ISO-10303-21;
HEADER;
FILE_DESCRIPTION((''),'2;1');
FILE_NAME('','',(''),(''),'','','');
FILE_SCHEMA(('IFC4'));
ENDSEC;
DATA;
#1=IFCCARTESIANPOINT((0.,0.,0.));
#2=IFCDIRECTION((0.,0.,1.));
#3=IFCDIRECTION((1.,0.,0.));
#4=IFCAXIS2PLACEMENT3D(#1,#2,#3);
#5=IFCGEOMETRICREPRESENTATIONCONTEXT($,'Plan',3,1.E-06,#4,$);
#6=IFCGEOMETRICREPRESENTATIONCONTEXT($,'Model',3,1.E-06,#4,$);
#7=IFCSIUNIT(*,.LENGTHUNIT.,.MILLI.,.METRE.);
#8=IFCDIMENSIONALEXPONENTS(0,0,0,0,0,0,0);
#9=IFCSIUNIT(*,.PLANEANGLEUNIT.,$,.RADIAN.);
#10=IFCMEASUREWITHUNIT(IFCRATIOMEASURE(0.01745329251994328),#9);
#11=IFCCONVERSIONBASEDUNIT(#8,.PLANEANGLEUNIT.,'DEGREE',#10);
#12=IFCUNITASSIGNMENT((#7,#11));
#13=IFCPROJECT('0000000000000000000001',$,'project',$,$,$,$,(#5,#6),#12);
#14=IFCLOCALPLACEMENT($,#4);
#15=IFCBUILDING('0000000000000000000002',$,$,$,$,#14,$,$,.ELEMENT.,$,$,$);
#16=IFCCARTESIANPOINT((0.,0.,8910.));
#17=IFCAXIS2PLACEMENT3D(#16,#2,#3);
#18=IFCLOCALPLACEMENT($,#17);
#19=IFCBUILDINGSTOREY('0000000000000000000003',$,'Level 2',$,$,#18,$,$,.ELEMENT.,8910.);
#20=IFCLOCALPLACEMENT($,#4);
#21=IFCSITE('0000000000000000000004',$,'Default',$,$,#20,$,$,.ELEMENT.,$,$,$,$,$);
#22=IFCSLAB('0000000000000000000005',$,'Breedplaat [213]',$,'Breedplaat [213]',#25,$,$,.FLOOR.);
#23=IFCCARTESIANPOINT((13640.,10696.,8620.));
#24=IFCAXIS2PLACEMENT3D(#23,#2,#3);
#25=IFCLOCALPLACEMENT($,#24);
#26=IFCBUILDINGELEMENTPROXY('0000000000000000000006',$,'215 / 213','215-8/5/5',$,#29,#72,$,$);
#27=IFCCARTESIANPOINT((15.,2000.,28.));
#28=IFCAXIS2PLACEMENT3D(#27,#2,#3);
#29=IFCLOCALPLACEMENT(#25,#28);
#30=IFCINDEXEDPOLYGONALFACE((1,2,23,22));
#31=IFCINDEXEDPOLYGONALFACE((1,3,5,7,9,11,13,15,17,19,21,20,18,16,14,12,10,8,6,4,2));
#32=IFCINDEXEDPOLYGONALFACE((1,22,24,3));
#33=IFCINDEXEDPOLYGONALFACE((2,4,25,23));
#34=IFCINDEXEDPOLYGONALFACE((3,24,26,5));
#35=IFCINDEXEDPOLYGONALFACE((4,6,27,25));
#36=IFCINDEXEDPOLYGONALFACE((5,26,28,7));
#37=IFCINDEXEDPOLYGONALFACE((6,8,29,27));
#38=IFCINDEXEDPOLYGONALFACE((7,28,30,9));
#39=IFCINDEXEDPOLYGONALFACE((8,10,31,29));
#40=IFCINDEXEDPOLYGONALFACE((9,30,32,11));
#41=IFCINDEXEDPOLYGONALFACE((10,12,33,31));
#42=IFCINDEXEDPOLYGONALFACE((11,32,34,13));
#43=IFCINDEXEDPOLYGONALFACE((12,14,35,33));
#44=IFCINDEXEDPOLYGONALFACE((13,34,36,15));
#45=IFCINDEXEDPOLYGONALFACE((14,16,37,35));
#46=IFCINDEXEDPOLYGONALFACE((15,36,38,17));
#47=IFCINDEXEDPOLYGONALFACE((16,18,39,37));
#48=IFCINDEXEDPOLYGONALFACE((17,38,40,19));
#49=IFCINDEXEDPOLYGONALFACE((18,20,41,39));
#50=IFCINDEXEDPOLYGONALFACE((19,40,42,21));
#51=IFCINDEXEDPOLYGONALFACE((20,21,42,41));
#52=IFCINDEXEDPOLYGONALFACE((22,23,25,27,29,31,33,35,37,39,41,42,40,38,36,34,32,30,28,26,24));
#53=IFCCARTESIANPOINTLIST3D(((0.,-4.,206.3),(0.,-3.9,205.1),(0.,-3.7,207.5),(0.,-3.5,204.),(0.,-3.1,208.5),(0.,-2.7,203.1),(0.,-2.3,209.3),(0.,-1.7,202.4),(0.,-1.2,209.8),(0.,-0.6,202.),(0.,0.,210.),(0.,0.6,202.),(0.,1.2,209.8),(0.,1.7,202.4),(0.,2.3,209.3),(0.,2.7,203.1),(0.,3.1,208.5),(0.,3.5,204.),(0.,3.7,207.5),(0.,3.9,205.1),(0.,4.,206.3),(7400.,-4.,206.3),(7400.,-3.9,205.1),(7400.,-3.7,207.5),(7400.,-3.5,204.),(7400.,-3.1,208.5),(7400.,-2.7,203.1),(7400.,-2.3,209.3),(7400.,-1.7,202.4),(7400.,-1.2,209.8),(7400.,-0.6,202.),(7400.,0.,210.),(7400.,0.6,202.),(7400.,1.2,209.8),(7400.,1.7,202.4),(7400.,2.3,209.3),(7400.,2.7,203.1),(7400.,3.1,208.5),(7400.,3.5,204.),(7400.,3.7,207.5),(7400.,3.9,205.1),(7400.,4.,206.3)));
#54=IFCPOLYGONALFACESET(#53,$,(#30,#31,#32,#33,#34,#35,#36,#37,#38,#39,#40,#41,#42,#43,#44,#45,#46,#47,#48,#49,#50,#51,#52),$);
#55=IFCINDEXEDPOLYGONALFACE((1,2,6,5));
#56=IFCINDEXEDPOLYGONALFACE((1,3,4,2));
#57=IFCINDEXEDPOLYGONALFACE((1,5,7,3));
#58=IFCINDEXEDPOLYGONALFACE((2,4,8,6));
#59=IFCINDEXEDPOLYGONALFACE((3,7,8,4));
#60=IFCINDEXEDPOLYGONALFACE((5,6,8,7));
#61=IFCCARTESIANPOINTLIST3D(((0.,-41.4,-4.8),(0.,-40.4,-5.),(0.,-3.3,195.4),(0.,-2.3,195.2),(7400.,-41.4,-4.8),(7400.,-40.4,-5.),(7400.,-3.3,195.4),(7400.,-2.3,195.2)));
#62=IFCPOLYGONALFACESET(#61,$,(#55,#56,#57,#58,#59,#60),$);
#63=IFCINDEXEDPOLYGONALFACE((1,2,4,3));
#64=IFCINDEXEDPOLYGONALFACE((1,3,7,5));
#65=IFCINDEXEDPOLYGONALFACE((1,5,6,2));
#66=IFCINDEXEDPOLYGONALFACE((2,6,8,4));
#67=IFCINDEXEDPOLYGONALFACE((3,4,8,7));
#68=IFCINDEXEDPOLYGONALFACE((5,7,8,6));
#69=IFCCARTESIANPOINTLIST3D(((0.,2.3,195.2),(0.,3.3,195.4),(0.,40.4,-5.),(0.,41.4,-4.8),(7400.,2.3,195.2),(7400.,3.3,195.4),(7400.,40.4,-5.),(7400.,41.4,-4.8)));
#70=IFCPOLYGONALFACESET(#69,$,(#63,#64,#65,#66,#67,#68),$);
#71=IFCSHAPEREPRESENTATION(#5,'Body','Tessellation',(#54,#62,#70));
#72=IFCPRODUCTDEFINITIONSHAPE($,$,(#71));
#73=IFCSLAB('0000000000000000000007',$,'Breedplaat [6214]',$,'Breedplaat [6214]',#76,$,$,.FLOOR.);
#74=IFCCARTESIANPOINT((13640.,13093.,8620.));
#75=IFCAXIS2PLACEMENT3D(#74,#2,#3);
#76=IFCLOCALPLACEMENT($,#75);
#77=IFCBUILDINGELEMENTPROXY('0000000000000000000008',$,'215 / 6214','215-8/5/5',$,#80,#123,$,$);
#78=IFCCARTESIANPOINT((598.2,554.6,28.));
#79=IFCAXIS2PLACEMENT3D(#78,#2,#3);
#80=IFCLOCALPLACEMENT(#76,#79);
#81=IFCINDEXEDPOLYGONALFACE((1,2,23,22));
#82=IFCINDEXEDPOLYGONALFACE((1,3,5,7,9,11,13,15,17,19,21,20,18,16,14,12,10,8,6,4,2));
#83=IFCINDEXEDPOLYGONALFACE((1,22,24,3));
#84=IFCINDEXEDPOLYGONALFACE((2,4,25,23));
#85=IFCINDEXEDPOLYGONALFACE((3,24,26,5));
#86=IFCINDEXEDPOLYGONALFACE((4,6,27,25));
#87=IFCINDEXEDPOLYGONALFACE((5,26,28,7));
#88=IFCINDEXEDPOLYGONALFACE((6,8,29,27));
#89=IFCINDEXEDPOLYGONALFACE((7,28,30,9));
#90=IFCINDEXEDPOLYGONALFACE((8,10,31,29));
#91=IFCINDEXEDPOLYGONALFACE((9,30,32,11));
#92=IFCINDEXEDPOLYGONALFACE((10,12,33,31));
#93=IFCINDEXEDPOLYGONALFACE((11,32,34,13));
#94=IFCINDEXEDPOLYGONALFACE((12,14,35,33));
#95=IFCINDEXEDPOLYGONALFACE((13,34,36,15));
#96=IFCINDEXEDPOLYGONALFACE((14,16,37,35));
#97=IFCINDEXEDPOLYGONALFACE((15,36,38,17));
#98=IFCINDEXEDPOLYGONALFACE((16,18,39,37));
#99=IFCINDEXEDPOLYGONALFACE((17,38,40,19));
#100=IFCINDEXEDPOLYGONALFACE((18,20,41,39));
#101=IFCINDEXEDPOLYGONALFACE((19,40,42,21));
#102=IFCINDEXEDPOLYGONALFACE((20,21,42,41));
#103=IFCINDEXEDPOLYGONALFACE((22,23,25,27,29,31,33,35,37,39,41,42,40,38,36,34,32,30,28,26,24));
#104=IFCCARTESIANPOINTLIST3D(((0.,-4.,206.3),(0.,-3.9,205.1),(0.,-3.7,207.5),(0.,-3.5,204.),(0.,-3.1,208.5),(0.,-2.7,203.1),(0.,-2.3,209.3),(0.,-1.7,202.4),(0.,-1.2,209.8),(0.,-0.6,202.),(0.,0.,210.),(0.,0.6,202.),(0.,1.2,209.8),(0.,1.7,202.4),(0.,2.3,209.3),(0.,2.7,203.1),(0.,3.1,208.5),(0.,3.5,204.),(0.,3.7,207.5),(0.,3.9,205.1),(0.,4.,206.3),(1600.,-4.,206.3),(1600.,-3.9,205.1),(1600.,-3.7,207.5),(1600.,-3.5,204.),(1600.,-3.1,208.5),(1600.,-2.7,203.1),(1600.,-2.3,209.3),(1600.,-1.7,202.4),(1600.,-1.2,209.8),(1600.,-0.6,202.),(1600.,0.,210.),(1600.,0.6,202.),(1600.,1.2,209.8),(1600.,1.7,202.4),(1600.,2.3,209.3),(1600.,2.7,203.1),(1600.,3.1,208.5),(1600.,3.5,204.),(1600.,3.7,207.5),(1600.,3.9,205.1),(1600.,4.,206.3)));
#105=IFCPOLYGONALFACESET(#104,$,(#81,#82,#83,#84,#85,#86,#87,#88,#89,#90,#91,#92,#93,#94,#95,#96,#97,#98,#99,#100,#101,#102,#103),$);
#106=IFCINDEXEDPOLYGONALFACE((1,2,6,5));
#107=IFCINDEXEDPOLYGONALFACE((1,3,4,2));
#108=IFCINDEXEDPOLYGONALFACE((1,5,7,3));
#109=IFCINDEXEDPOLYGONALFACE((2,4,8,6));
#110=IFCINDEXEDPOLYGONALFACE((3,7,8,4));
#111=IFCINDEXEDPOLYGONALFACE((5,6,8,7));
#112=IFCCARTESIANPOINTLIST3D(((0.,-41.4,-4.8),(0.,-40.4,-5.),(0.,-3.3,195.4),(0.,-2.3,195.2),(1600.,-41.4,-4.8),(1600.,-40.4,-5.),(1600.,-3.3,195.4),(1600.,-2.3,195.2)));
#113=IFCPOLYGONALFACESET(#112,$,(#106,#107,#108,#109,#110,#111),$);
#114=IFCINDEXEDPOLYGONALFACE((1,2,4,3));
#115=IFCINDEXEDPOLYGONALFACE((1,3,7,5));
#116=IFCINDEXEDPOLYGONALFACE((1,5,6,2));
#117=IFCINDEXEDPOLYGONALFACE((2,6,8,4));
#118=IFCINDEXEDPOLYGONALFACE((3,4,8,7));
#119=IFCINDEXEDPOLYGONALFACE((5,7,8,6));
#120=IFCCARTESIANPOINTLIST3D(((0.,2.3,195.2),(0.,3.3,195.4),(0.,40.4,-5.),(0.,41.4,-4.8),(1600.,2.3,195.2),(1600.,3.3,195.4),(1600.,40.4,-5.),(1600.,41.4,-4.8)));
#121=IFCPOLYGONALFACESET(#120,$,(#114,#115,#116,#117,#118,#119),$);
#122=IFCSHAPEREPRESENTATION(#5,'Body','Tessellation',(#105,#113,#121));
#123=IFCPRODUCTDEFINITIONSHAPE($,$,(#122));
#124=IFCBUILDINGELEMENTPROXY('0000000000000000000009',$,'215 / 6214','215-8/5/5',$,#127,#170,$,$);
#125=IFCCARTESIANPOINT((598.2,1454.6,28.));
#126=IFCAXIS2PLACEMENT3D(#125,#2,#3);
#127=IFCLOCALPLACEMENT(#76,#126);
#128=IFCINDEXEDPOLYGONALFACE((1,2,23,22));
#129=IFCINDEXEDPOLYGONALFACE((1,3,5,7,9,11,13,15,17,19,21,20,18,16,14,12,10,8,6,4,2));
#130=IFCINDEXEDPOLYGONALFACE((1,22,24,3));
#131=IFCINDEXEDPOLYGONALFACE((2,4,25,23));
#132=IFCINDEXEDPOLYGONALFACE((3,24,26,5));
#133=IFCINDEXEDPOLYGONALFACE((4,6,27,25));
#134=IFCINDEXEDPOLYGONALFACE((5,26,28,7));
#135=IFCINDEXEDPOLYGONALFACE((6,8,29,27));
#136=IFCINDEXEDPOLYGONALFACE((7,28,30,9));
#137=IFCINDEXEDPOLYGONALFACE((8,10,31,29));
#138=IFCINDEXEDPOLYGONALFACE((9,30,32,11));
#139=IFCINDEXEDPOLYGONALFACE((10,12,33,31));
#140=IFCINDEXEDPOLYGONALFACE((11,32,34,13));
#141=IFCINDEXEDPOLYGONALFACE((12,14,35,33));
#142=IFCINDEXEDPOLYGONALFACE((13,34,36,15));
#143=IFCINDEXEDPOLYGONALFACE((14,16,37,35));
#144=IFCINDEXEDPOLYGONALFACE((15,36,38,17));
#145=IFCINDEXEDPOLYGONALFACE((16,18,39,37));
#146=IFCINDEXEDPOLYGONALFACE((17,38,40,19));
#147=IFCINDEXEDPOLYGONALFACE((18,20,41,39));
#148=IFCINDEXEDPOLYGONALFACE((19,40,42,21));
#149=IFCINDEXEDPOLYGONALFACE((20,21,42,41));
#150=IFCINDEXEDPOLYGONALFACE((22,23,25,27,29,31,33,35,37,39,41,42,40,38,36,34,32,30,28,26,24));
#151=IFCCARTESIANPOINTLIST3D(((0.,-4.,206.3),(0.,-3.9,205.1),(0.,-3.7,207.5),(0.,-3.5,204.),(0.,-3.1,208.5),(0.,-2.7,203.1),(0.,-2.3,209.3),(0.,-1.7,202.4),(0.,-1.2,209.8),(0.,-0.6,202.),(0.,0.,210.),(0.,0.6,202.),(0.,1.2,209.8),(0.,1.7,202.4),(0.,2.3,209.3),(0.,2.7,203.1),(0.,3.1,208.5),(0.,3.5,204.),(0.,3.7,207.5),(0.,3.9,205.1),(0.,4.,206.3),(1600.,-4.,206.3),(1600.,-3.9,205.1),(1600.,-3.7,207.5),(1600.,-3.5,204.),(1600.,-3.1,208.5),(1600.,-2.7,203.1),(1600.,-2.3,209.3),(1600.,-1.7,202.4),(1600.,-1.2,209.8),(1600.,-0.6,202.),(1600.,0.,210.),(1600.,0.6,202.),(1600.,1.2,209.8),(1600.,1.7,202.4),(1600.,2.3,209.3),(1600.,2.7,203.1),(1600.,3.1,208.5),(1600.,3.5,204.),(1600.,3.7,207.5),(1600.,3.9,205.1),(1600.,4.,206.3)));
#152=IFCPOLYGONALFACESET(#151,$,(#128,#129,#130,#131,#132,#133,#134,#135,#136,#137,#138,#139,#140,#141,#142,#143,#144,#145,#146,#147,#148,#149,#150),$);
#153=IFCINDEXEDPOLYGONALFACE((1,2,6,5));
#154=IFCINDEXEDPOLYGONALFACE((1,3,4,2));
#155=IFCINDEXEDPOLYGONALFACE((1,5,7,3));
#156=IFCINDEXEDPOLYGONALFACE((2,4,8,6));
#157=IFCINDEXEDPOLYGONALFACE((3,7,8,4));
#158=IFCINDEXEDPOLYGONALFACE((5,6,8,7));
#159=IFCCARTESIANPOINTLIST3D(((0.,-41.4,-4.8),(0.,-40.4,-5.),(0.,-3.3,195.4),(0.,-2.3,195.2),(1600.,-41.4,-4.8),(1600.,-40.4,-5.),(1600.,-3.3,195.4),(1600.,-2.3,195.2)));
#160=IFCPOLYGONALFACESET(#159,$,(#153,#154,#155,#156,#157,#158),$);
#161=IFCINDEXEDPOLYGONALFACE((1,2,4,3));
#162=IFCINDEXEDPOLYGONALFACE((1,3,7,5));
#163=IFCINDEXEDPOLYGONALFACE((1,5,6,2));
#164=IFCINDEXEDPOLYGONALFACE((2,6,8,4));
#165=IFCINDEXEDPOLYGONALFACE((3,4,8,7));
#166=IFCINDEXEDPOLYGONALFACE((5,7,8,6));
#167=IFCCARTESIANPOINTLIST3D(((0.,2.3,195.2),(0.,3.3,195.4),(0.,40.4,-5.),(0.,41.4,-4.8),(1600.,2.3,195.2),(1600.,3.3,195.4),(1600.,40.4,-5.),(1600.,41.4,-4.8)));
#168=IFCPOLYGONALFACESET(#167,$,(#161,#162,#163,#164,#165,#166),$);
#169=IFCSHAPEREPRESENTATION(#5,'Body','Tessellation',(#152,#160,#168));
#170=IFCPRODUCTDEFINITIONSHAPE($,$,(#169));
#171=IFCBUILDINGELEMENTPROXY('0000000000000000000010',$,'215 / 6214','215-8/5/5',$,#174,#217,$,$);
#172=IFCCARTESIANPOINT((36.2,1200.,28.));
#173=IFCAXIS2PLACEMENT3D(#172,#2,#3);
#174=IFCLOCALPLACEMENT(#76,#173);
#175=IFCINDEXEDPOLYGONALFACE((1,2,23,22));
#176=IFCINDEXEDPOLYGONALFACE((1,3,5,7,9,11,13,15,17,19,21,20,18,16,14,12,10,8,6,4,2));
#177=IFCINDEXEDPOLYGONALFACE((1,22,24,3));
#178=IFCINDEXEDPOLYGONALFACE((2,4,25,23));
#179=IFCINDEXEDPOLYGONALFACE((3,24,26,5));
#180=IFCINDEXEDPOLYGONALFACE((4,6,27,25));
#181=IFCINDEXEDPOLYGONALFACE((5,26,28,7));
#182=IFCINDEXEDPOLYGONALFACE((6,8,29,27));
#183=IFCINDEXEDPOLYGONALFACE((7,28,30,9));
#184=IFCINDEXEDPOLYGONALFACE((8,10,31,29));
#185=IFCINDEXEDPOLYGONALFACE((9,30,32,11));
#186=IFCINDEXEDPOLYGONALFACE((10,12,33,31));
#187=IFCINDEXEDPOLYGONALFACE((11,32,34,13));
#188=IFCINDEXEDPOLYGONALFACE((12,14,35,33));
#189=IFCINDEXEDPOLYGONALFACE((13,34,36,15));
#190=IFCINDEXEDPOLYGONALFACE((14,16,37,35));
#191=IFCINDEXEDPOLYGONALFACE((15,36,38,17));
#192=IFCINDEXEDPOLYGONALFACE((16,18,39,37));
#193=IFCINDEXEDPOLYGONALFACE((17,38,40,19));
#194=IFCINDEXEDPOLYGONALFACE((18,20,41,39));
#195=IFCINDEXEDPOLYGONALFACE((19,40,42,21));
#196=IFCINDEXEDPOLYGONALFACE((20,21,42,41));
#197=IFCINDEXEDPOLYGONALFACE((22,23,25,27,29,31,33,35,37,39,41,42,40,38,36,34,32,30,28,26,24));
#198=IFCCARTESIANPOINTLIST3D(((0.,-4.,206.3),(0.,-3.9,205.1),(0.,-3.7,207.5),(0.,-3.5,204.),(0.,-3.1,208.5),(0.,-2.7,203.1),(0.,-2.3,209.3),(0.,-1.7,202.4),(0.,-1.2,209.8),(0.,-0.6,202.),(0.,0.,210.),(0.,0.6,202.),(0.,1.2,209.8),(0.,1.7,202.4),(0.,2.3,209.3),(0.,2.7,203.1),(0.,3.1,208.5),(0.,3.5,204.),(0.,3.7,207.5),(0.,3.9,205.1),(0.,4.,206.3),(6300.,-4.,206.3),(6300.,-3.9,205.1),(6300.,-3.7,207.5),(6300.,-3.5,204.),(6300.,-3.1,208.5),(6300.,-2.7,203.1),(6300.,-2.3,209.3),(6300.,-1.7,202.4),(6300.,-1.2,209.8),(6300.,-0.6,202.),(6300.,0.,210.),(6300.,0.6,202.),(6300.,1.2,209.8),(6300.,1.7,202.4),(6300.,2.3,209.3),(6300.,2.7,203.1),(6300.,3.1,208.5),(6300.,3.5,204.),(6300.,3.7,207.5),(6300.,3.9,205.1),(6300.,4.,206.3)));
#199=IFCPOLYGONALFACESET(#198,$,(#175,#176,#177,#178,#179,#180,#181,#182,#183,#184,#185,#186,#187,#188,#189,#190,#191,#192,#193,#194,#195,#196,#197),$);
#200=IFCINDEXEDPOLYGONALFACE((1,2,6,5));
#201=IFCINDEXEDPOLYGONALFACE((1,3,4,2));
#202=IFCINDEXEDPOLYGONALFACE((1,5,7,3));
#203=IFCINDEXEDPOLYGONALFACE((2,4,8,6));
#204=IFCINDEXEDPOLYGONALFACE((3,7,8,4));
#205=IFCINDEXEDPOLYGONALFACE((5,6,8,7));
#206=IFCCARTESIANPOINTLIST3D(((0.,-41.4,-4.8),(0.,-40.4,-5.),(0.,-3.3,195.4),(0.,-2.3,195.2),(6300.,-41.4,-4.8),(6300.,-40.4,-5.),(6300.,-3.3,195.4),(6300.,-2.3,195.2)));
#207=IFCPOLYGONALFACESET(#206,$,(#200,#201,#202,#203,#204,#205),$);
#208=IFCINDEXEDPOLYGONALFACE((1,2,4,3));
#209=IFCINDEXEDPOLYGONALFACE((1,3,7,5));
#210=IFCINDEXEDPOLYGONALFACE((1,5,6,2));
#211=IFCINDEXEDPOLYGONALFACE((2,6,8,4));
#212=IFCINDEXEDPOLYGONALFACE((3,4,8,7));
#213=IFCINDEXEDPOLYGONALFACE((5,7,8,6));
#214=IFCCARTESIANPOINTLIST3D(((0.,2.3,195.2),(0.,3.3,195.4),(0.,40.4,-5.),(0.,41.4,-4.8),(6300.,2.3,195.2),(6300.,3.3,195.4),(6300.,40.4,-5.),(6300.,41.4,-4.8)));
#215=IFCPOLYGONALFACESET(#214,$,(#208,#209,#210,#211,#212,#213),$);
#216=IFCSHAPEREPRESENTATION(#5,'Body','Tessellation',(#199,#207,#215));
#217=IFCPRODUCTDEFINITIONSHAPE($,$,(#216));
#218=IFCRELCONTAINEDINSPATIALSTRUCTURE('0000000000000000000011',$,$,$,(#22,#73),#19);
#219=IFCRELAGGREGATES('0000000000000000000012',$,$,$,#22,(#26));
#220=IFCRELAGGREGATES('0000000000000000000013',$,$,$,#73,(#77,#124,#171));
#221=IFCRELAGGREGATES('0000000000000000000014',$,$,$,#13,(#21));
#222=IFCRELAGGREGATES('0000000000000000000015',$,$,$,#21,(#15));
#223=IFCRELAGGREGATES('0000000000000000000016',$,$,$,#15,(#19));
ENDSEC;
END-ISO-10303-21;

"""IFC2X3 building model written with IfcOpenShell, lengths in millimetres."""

from ifc_helpers import new_model, entity, si_unit, converted_unit, frame, origin_with_axes, origin_2d_with_axis, place, context, project, spatial, rectangle, circle, extrude, element, aggregate, save


model = new_model("IFC2X3")

# Units and contexts
plan_context = context("Plan", 3, precision=1e-06, world=origin_with_axes())
model_context = context("Model", 3, precision=1e-06, world=origin_with_axes())
ifc_project = project(units=[si_unit("LENGTHUNIT", "METRE", prefix="MILLI"), converted_unit("PLANEANGLEUNIT", "DEGREE", entity("IfcRatioMeasure", 0.01745329251994328), si_unit("PLANEANGLEUNIT", "RADIAN"), dimensions=[0, 0, 0, 0, 0, 0, 0])], contexts=[plan_context, model_context])

# Site, building, storey
site_placement = place(None, origin_with_axes())
site = spatial("IfcSite", under=ifc_project, at=site_placement, Name="Default", CompositionType="ELEMENT")
building_placement = place(None, origin_with_axes())
building = spatial("IfcBuilding", under=site, at=building_placement, CompositionType="ELEMENT")
storey_placement = place(None, frame((0.0, 0.0, 8910.0), z_axis=(0.0, 0.0, 1.0), x_axis=(1.0, 0.0, 0.0)))
storey = spatial("IfcBuildingStorey", under=building, at=storey_placement, Name="Level 2", CompositionType="ELEMENT", Elevation=8910.0)

# Slabs, building element proxies
slab_1_placement = place(None, frame((13640.0, 10696.0, 8620.0), z_axis=(0.0, 0.0, 1.0), x_axis=(1.0, 0.0, 0.0)))
slab_1 = element("IfcSlab", 1, at=slab_1_placement, inside=storey, Name="Breedplaat [213]", ObjectType="Breedplaat [213]", PredefinedType="FLOOR")
proxy_1_placement = place(slab_1_placement, frame((15.0, 2000.0, 28.0), z_axis=(0.0, 0.0, 1.0), x_axis=(1.0, 0.0, 0.0)))
proxy_1 = element("IfcBuildingElementProxy", 2, at=proxy_1_placement, Name="215 / 213", Description="215-8/5/5", context=plan_context, shape_type="SweptSolid", body=[
    extrude(circle(Radius=4.0, at=origin_2d_with_axis()), frame((0.0, 0.0, 206.0), z_axis=(1.0, 0.0, 0.0), x_axis=(0.0, 0.0, 1.0)), (0.0, 0.0, 1.0), 7400.0),
    extrude(rectangle(XDim=203.8, YDim=1.0, at=origin_2d_with_axis()), frame((0.0, -21.9, 95.2), z_axis=(1.0, 0.0, 0.0), x_axis=(0.0, 0.187112, 0.982339)), (0.0, 0.0, 1.0), 7400.0),
    extrude(rectangle(XDim=203.8, YDim=1.0, at=origin_2d_with_axis()), frame((0.0, 21.9, 95.2), z_axis=(1.0, 0.0, 0.0), x_axis=(0.0, -0.187112, 0.982339)), (0.0, 0.0, 1.0), 7400.0),
])
aggregate(slab_1, [proxy_1])
slab_2_placement = place(None, frame((13640.0, 13093.0, 8620.0), z_axis=(0.0, 0.0, 1.0), x_axis=(1.0, 0.0, 0.0)))
slab_2 = element("IfcSlab", 3, at=slab_2_placement, inside=storey, Name="Breedplaat [6214]", ObjectType="Breedplaat [6214]", PredefinedType="FLOOR")
proxy_2_placement = place(slab_2_placement, frame((598.2, 554.6, 28.0), z_axis=(0.0, 0.0, 1.0), x_axis=(1.0, 0.0, 0.0)))
proxy_2 = element("IfcBuildingElementProxy", 4, at=proxy_2_placement, Name="215 / 6214", Description="215-8/5/5", context=plan_context, shape_type="SweptSolid", body=[
    extrude(circle(Radius=4.0, at=origin_2d_with_axis()), frame((0.0, 0.0, 206.0), z_axis=(1.0, 0.0, 0.0), x_axis=(0.0, 0.0, 1.0)), (0.0, 0.0, 1.0), 1600.0),
    extrude(rectangle(XDim=203.8, YDim=1.0, at=origin_2d_with_axis()), frame((0.0, -21.9, 95.2), z_axis=(1.0, 0.0, 0.0), x_axis=(0.0, 0.187112, 0.982339)), (0.0, 0.0, 1.0), 1600.0),
    extrude(rectangle(XDim=203.8, YDim=1.0, at=origin_2d_with_axis()), frame((0.0, 21.9, 95.2), z_axis=(1.0, 0.0, 0.0), x_axis=(0.0, -0.187112, 0.982339)), (0.0, 0.0, 1.0), 1600.0),
])
proxy_3_placement = place(slab_2_placement, frame((598.2, 1454.6, 28.0), z_axis=(0.0, 0.0, 1.0), x_axis=(1.0, 0.0, 0.0)))
proxy_3 = element("IfcBuildingElementProxy", 5, at=proxy_3_placement, Name="215 / 6214", Description="215-8/5/5", context=plan_context, shape_type="SweptSolid", body=[
    extrude(circle(Radius=4.0, at=origin_2d_with_axis()), frame((0.0, 0.0, 206.0), z_axis=(1.0, 0.0, 0.0), x_axis=(0.0, 0.0, 1.0)), (0.0, 0.0, 1.0), 1600.0),
    extrude(rectangle(XDim=203.8, YDim=1.0, at=origin_2d_with_axis()), frame((0.0, -21.9, 95.2), z_axis=(1.0, 0.0, 0.0), x_axis=(0.0, 0.187112, 0.982339)), (0.0, 0.0, 1.0), 1600.0),
    extrude(rectangle(XDim=203.8, YDim=1.0, at=origin_2d_with_axis()), frame((0.0, 21.9, 95.2), z_axis=(1.0, 0.0, 0.0), x_axis=(0.0, -0.187112, 0.982339)), (0.0, 0.0, 1.0), 1600.0),
])
proxy_4_placement = place(slab_2_placement, frame((36.2, 1200.0, 28.0), z_axis=(0.0, 0.0, 1.0), x_axis=(1.0, 0.0, 0.0)))
proxy_4 = element("IfcBuildingElementProxy", 6, at=proxy_4_placement, Name="215 / 6214", Description="215-8/5/5", context=plan_context, shape_type="SweptSolid", body=[
    extrude(circle(Radius=4.0, at=origin_2d_with_axis()), frame((0.0, 0.0, 206.0), z_axis=(1.0, 0.0, 0.0), x_axis=(0.0, 0.0, 1.0)), (0.0, 0.0, 1.0), 6300.0),
    extrude(rectangle(XDim=203.8, YDim=1.0, at=origin_2d_with_axis()), frame((0.0, -21.9, 95.2), z_axis=(1.0, 0.0, 0.0), x_axis=(0.0, 0.187112, 0.982339)), (0.0, 0.0, 1.0), 6300.0),
    extrude(rectangle(XDim=203.8, YDim=1.0, at=origin_2d_with_axis()), frame((0.0, 21.9, 95.2), z_axis=(1.0, 0.0, 0.0), x_axis=(0.0, -0.187112, 0.982339)), (0.0, 0.0, 1.0), 6300.0),
])
aggregate(slab_2, [proxy_2, proxy_3, proxy_4])

save(model, "model.ifc")
